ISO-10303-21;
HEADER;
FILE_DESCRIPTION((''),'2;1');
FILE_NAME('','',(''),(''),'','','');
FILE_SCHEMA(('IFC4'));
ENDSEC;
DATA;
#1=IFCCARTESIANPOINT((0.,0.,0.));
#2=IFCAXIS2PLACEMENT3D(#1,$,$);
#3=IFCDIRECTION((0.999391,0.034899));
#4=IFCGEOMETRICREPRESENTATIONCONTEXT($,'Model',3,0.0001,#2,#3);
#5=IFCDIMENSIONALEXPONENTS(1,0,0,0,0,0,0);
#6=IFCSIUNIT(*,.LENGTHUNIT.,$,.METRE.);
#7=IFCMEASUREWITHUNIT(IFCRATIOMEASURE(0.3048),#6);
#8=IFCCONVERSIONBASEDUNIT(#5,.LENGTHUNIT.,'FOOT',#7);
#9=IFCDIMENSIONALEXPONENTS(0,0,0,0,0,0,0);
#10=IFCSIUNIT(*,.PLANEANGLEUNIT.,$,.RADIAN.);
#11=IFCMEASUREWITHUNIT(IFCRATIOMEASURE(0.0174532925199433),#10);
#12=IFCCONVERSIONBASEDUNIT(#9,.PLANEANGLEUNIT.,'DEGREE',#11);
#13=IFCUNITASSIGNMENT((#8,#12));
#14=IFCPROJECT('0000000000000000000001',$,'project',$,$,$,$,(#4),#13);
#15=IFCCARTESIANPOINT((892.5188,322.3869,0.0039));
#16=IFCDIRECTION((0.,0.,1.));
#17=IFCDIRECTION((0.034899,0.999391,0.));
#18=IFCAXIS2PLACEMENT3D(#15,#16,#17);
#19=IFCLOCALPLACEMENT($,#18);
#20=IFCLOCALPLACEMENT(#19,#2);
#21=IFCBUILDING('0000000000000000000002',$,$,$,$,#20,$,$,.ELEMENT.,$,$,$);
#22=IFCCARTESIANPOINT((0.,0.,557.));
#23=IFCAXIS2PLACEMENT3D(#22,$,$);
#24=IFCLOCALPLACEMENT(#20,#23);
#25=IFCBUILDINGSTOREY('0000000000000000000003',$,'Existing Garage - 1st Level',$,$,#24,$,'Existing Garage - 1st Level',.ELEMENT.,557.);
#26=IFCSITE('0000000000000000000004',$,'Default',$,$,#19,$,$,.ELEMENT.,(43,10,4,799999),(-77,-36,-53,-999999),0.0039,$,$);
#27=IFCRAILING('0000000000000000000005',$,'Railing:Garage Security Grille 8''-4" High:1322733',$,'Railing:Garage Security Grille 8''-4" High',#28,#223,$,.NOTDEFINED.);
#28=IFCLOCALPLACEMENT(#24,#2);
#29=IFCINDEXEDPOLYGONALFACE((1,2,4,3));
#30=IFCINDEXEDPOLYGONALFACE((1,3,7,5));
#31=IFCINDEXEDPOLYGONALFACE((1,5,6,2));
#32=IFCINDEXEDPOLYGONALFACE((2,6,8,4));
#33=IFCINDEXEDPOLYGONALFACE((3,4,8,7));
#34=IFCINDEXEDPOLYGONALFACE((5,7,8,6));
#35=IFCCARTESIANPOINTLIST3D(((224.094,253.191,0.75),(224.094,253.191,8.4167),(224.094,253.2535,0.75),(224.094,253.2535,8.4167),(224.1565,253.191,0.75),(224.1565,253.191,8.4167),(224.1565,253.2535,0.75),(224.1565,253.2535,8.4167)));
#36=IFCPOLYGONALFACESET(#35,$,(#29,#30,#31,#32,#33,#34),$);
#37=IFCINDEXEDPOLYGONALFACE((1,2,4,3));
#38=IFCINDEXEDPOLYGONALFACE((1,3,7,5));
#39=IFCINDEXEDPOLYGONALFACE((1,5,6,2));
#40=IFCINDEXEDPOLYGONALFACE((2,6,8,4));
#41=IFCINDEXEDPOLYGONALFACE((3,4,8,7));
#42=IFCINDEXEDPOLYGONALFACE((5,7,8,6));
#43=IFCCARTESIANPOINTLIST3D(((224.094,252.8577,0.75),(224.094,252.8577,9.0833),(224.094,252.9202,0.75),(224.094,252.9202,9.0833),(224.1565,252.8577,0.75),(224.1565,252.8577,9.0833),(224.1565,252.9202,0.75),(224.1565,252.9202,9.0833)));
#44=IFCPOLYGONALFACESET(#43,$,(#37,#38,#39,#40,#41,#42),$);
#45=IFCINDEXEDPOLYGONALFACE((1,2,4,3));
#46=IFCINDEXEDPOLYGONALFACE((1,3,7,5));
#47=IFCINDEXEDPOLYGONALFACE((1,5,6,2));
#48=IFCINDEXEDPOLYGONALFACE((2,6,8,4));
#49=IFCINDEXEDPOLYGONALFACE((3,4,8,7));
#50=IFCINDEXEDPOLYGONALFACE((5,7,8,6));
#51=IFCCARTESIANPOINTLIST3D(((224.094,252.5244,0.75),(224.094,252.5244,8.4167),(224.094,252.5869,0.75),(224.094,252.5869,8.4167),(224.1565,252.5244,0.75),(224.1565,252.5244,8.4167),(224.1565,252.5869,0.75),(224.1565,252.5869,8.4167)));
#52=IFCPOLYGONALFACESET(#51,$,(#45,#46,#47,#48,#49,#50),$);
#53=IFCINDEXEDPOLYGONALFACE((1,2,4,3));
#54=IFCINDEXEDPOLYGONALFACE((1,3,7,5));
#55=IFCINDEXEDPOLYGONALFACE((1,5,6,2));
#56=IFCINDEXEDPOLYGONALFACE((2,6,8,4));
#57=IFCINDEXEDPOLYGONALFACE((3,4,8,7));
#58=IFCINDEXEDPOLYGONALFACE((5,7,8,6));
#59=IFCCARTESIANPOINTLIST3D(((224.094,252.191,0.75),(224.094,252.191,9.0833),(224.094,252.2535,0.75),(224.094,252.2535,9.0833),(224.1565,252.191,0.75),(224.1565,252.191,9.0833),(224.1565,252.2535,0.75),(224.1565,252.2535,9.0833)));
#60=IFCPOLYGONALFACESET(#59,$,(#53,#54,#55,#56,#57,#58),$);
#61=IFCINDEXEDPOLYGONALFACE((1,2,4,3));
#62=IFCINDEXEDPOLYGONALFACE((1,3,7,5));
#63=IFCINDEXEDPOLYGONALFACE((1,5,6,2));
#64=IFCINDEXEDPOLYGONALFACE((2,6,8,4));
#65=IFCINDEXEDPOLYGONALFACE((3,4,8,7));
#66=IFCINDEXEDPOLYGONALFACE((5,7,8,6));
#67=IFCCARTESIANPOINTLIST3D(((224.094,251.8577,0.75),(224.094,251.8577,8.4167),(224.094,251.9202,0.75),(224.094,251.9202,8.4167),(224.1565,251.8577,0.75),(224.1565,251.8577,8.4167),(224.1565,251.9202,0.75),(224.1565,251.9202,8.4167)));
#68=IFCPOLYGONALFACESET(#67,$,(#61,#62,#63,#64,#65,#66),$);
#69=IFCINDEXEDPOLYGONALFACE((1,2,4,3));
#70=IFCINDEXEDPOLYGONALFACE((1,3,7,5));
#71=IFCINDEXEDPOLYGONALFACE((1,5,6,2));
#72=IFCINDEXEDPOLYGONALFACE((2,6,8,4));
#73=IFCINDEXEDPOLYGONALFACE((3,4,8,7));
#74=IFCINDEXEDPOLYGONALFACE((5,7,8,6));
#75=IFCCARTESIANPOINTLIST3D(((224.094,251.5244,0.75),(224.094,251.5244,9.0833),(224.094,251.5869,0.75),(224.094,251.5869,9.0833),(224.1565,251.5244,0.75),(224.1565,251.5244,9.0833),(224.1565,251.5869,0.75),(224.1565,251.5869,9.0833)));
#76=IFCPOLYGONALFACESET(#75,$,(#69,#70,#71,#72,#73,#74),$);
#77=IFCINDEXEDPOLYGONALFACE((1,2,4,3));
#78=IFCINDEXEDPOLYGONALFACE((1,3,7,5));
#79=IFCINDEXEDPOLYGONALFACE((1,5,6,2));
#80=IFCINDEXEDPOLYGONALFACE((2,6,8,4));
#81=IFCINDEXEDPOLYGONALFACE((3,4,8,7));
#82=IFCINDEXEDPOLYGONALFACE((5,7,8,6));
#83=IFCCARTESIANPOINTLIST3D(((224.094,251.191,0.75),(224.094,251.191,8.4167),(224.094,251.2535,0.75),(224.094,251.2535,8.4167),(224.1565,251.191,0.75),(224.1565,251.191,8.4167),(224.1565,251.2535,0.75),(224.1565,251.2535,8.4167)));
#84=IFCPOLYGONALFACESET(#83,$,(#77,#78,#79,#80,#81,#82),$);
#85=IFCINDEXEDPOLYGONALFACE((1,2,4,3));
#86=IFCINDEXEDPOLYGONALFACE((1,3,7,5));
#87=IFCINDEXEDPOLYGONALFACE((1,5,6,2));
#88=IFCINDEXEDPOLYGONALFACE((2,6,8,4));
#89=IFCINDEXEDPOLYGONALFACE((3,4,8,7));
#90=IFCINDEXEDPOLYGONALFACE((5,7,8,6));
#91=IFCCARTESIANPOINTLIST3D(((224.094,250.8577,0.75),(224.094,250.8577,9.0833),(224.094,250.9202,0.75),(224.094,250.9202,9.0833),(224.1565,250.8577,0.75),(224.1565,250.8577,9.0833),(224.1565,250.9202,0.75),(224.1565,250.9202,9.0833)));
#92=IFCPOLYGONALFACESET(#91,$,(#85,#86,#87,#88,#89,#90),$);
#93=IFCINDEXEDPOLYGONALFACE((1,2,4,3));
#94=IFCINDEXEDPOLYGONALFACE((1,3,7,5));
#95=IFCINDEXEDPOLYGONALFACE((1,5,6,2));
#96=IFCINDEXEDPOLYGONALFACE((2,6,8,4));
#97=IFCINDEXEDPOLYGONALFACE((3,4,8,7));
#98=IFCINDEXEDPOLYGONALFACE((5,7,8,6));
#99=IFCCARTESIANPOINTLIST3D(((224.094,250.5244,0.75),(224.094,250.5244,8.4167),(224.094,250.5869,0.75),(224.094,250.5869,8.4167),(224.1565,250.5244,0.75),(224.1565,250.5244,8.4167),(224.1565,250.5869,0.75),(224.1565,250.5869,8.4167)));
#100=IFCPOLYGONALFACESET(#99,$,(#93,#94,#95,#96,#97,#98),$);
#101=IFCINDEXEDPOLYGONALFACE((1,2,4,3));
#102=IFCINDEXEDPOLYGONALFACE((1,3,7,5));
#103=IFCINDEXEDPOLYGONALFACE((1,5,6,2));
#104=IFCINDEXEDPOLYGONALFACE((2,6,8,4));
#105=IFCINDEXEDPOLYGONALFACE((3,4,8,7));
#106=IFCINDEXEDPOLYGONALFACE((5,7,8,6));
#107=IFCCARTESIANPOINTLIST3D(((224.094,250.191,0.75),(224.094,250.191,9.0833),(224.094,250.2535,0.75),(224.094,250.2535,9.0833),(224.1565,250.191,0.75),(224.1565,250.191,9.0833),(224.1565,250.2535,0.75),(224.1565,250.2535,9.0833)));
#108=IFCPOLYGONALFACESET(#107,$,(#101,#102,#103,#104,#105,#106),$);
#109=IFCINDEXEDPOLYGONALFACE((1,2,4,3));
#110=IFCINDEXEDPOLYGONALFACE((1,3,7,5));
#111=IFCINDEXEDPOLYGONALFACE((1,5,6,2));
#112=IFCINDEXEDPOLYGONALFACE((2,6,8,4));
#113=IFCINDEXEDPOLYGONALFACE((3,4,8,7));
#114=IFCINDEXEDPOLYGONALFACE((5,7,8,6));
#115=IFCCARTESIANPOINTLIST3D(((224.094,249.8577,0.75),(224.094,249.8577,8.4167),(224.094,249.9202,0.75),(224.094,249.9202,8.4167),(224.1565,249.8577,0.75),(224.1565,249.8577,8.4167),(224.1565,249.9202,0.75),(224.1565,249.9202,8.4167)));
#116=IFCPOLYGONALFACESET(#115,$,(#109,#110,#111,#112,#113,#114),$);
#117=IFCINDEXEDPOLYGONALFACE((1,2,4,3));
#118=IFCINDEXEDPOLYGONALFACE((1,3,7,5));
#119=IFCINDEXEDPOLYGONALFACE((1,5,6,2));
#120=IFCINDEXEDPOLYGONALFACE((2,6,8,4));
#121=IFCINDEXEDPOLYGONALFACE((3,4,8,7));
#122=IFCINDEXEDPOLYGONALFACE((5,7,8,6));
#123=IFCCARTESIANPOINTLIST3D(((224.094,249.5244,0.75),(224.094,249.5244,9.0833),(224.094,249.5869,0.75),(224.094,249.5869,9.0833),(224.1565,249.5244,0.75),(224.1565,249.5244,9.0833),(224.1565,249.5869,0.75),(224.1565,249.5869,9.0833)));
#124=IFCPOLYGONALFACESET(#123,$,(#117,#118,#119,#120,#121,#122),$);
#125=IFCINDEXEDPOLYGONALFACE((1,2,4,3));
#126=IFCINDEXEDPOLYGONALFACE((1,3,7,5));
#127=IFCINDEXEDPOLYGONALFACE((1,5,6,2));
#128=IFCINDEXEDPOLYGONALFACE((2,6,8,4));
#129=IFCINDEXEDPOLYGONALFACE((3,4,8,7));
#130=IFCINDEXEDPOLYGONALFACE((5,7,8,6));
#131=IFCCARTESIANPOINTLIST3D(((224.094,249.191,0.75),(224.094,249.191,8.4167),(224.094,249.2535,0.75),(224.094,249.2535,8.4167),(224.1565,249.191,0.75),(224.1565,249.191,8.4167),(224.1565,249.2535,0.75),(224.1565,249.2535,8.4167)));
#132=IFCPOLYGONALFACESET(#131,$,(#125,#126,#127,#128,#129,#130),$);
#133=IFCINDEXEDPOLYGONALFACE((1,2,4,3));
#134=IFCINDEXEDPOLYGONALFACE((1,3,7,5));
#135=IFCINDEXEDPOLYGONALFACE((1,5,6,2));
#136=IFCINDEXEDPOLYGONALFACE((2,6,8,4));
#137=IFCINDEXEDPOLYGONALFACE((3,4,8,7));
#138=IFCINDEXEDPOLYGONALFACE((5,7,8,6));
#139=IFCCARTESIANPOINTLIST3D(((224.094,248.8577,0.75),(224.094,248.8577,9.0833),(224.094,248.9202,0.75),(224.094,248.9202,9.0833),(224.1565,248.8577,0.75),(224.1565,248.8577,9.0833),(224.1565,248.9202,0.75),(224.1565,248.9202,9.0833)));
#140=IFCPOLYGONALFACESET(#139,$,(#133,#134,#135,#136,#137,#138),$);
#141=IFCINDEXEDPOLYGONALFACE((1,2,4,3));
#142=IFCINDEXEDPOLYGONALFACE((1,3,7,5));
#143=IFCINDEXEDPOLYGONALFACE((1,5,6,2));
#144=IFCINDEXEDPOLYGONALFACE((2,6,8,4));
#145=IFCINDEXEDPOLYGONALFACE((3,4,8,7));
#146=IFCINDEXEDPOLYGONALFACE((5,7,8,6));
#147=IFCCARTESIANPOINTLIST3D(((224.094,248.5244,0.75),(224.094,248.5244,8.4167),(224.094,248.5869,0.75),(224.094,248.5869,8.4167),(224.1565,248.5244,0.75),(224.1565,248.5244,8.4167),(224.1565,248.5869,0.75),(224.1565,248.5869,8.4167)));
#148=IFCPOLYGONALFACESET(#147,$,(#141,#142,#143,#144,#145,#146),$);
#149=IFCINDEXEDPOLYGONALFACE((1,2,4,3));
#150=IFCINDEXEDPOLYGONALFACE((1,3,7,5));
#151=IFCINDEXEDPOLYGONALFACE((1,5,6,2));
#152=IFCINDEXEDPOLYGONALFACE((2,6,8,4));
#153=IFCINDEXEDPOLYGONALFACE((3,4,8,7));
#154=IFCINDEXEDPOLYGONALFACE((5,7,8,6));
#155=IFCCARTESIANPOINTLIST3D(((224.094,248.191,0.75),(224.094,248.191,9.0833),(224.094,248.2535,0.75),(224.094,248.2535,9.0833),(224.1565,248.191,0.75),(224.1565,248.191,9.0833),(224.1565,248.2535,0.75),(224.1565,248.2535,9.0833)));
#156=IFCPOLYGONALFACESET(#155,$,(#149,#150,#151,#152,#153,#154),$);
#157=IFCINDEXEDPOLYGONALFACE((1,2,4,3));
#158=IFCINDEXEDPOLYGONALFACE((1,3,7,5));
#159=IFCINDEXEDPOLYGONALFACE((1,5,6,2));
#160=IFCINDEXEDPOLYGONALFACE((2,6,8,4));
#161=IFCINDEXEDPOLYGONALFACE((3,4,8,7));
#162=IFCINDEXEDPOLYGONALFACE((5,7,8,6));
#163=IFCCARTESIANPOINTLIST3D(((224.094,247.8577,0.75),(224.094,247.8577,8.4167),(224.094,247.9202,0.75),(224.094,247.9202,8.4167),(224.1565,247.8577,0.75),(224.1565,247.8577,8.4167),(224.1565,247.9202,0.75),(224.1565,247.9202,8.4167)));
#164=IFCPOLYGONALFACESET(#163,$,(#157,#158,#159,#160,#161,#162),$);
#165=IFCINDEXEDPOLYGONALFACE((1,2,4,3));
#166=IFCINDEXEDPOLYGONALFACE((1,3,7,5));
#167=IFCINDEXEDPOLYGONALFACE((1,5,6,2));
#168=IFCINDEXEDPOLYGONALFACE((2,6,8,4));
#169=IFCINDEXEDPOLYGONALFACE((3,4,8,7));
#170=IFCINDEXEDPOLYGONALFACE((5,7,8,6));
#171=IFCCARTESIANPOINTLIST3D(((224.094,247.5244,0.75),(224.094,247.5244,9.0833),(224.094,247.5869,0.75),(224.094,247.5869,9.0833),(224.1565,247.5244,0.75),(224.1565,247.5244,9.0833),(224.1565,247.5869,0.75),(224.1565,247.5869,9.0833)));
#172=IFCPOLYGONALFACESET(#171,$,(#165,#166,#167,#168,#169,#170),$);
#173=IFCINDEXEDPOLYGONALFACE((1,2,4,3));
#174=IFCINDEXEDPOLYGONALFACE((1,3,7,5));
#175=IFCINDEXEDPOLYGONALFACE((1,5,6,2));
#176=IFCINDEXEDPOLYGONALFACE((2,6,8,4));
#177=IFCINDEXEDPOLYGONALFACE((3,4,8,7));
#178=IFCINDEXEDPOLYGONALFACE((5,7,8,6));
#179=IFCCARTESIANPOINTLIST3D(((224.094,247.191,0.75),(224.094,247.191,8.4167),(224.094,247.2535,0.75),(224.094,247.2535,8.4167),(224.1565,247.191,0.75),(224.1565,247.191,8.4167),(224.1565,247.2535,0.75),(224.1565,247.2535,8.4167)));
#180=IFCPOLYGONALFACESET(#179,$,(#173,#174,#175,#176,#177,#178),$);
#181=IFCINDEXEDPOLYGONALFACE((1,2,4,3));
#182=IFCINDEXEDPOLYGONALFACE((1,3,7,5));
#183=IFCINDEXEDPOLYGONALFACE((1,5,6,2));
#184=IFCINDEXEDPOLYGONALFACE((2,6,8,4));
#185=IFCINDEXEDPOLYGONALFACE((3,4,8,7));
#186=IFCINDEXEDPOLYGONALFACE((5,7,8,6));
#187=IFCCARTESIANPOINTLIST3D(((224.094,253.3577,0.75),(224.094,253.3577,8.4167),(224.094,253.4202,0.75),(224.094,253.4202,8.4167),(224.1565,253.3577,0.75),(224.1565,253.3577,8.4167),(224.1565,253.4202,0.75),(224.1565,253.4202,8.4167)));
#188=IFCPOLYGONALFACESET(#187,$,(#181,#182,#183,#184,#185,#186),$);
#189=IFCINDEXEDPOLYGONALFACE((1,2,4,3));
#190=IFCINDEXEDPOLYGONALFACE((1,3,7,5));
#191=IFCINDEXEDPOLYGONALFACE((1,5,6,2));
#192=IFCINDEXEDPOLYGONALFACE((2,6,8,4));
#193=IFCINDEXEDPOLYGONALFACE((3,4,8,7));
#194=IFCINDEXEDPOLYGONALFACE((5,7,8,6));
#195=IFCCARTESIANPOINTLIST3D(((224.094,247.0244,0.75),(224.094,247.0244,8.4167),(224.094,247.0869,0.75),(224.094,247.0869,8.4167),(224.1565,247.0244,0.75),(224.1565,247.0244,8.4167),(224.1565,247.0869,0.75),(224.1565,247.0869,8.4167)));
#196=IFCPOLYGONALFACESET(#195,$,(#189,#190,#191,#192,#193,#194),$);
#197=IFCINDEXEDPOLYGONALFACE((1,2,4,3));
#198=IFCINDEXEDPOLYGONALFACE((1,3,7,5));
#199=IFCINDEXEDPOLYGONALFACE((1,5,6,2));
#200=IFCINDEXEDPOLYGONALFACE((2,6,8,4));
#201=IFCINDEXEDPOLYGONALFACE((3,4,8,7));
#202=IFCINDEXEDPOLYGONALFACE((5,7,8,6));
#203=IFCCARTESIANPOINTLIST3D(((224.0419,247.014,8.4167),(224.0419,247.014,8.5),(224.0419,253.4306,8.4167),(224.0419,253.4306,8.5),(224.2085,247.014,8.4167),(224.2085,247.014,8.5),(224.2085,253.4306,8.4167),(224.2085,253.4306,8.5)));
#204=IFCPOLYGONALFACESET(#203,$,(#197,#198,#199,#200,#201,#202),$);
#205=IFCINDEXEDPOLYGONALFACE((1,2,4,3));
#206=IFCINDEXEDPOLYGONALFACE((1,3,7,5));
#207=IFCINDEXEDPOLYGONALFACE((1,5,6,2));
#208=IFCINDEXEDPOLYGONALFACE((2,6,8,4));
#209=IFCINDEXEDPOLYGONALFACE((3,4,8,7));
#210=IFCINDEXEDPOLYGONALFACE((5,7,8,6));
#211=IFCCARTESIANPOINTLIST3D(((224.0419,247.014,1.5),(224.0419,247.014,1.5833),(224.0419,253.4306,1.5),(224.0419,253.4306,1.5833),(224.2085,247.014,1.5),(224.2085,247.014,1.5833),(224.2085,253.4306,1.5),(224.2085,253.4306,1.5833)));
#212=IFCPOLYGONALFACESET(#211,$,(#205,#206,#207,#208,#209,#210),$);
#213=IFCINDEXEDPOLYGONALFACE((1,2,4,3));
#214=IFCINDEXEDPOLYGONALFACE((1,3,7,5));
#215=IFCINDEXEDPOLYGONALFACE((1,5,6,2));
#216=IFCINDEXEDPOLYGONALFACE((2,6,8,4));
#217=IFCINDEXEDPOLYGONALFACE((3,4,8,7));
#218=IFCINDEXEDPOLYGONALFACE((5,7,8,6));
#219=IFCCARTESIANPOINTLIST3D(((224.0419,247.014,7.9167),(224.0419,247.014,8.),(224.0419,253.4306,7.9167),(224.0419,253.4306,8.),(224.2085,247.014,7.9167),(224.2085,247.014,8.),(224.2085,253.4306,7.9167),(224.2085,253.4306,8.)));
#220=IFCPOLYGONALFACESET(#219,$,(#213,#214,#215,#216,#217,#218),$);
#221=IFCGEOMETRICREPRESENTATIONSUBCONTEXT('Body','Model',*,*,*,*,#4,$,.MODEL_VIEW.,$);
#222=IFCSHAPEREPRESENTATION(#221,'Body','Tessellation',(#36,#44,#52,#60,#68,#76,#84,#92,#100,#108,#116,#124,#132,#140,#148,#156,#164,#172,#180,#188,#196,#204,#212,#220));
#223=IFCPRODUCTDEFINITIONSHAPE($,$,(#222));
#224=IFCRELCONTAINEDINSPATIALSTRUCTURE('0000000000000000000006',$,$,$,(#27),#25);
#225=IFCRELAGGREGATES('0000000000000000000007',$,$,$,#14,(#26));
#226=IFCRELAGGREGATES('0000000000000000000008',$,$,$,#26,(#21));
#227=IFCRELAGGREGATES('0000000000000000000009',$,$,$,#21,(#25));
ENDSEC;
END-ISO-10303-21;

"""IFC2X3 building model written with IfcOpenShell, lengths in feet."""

from ifc_helpers import new_model, entity, si_unit, converted_unit, direction, frame, frame_2d, origin, origin_2d_with_axis, place, context, subcontext, project, spatial, rectangle, extrude, element, save


model = new_model("IFC2X3")

# Units and contexts
model_context = context("Model", 3, precision=0.0001, world=origin(), true_north=direction((0.999391, 0.034899)))
body_context = subcontext(model_context, "Body", "Model", "MODEL_VIEW")
ifc_project = project(units=[converted_unit("LENGTHUNIT", "FOOT", entity("IfcRatioMeasure", 0.3048), si_unit("LENGTHUNIT", "METRE"), dimensions=[1, 0, 0, 0, 0, 0, 0]), converted_unit("PLANEANGLEUNIT", "DEGREE", entity("IfcRatioMeasure", 0.0174532925199433), si_unit("PLANEANGLEUNIT", "RADIAN"), dimensions=[0, 0, 0, 0, 0, 0, 0])], contexts=[model_context])

# Site, building, storey
site_placement = place(None, frame((892.5188, 322.3869, 0.0039), z_axis=(0.0, 0.0, 1.0), x_axis=(0.034899, 0.999391, 0.0)))
site = spatial("IfcSite", under=ifc_project, at=site_placement, Name="Default", CompositionType="ELEMENT", RefLatitude=(43, 10, 4, 799999), RefLongitude=(-77, -36, -53, -999999), RefElevation=0.0039)
building_placement = place(site_placement, origin())
building = spatial("IfcBuilding", under=site, at=building_placement, CompositionType="ELEMENT")
storey_placement = place(building_placement, frame((0.0, 0.0, 557.0)))
storey = spatial("IfcBuildingStorey", under=building, at=storey_placement, Name="Existing Garage - 1st Level", LongName="Existing Garage - 1st Level", CompositionType="ELEMENT", Elevation=557.0)

# Railing
railing_1_placement = place(storey_placement, origin())
element("IfcRailing", 1, at=railing_1_placement, inside=storey, Name="Railing:Garage Security Grille 8'-4\" High:1322733", ObjectType="Railing:Garage Security Grille 8'-4\" High", PredefinedType="NOTDEFINED", context=body_context, shape_type="SweptSolid", body=[
    extrude(rectangle(XDim=0.0625, YDim=0.0625, at=origin_2d_with_axis()), frame((224.1252, 253.2223, 0.75), z_axis=(0.0, 0.0, 1.0), x_axis=(0.0, 1.0, 0.0)), (0.0, 0.0, 1.0), 7.6667),
    extrude(rectangle(XDim=0.0625, YDim=0.0625, at=origin_2d_with_axis()), frame((224.1252, 252.889, 0.75), z_axis=(0.0, 0.0, 1.0), x_axis=(0.0, 1.0, 0.0)), (0.0, 0.0, 1.0), 8.3333),
    extrude(rectangle(XDim=0.0625, YDim=0.0625, at=origin_2d_with_axis()), frame((224.1252, 252.5556, 0.75), z_axis=(0.0, 0.0, 1.0), x_axis=(0.0, 1.0, 0.0)), (0.0, 0.0, 1.0), 7.6667),
    extrude(rectangle(XDim=0.0625, YDim=0.0625, at=origin_2d_with_axis()), frame((224.1252, 252.2223, 0.75), z_axis=(0.0, 0.0, 1.0), x_axis=(0.0, 1.0, 0.0)), (0.0, 0.0, 1.0), 8.3333),
    extrude(rectangle(XDim=0.0625, YDim=0.0625, at=origin_2d_with_axis()), frame((224.1252, 251.889, 0.75), z_axis=(0.0, 0.0, 1.0), x_axis=(0.0, 1.0, 0.0)), (0.0, 0.0, 1.0), 7.6667),
    extrude(rectangle(XDim=0.0625, YDim=0.0625, at=origin_2d_with_axis()), frame((224.1252, 251.5556, 0.75), z_axis=(0.0, 0.0, 1.0), x_axis=(0.0, 1.0, 0.0)), (0.0, 0.0, 1.0), 8.3333),
    extrude(rectangle(XDim=0.0625, YDim=0.0625, at=origin_2d_with_axis()), frame((224.1252, 251.2223, 0.75), z_axis=(0.0, 0.0, 1.0), x_axis=(0.0, 1.0, 0.0)), (0.0, 0.0, 1.0), 7.6667),
    extrude(rectangle(XDim=0.0625, YDim=0.0625, at=origin_2d_with_axis()), frame((224.1252, 250.889, 0.75), z_axis=(0.0, 0.0, 1.0), x_axis=(0.0, 1.0, 0.0)), (0.0, 0.0, 1.0), 8.3333),
    extrude(rectangle(XDim=0.0625, YDim=0.0625, at=origin_2d_with_axis()), frame((224.1252, 250.5556, 0.75), z_axis=(0.0, 0.0, 1.0), x_axis=(0.0, 1.0, 0.0)), (0.0, 0.0, 1.0), 7.6667),
    extrude(rectangle(XDim=0.0625, YDim=0.0625, at=origin_2d_with_axis()), frame((224.1252, 250.2223, 0.75), z_axis=(0.0, 0.0, 1.0), x_axis=(0.0, 1.0, 0.0)), (0.0, 0.0, 1.0), 8.3333),
    extrude(rectangle(XDim=0.0625, YDim=0.0625, at=origin_2d_with_axis()), frame((224.1252, 249.889, 0.75), z_axis=(0.0, 0.0, 1.0), x_axis=(0.0, 1.0, 0.0)), (0.0, 0.0, 1.0), 7.6667),
    extrude(rectangle(XDim=0.0625, YDim=0.0625, at=origin_2d_with_axis()), frame((224.1252, 249.5556, 0.75), z_axis=(0.0, 0.0, 1.0), x_axis=(0.0, 1.0, 0.0)), (0.0, 0.0, 1.0), 8.3333),
    extrude(rectangle(XDim=0.0625, YDim=0.0625, at=origin_2d_with_axis()), frame((224.1252, 249.2223, 0.75), z_axis=(0.0, 0.0, 1.0), x_axis=(0.0, 1.0, 0.0)), (0.0, 0.0, 1.0), 7.6667),
    extrude(rectangle(XDim=0.0625, YDim=0.0625, at=origin_2d_with_axis()), frame((224.1252, 248.889, 0.75), z_axis=(0.0, 0.0, 1.0), x_axis=(0.0, 1.0, 0.0)), (0.0, 0.0, 1.0), 8.3333),
    extrude(rectangle(XDim=0.0625, YDim=0.0625, at=origin_2d_with_axis()), frame((224.1252, 248.5556, 0.75), z_axis=(0.0, 0.0, 1.0), x_axis=(0.0, 1.0, 0.0)), (0.0, 0.0, 1.0), 7.6667),
    extrude(rectangle(XDim=0.0625, YDim=0.0625, at=origin_2d_with_axis()), frame((224.1252, 248.2223, 0.75), z_axis=(0.0, 0.0, 1.0), x_axis=(0.0, 1.0, 0.0)), (0.0, 0.0, 1.0), 8.3333),
    extrude(rectangle(XDim=0.0625, YDim=0.0625, at=origin_2d_with_axis()), frame((224.1252, 247.889, 0.75), z_axis=(0.0, 0.0, 1.0), x_axis=(0.0, 1.0, 0.0)), (0.0, 0.0, 1.0), 7.6667),
    extrude(rectangle(XDim=0.0625, YDim=0.0625, at=origin_2d_with_axis()), frame((224.1252, 247.5556, 0.75), z_axis=(0.0, 0.0, 1.0), x_axis=(0.0, 1.0, 0.0)), (0.0, 0.0, 1.0), 8.3333),
    extrude(rectangle(XDim=0.0625, YDim=0.0625, at=origin_2d_with_axis()), frame((224.1252, 247.2223, 0.75), z_axis=(0.0, 0.0, 1.0), x_axis=(0.0, 1.0, 0.0)), (0.0, 0.0, 1.0), 7.6667),
    extrude(rectangle(XDim=0.0625, YDim=0.0625, at=origin_2d_with_axis()), frame((224.1252, 253.389, 0.75), z_axis=(0.0, 0.0, 1.0), x_axis=(0.0, 1.0, 0.0)), (0.0, 0.0, 1.0), 7.6667),
    extrude(rectangle(XDim=0.0625, YDim=0.0625, at=origin_2d_with_axis()), frame((224.1252, 247.0556, 0.75), z_axis=(0.0, 0.0, 1.0), x_axis=(0.0, 1.0, 0.0)), (0.0, 0.0, 1.0), 7.6667),
    extrude(rectangle(XDim=6.4167, YDim=0.1667, at=frame_2d((0.0, 0.0), x_axis=(1.0, 0.0))), frame((224.1252, 250.2223, 8.4167), z_axis=(0.0, 0.0, 1.0), x_axis=(0.0, 1.0, 0.0)), (0.0, 0.0, 1.0), 0.0833),
    extrude(rectangle(XDim=6.4167, YDim=0.1667, at=frame_2d((0.0, 0.0), x_axis=(1.0, 0.0))), frame((224.1252, 250.2223, 1.5), z_axis=(0.0, 0.0, 1.0), x_axis=(0.0, 1.0, 0.0)), (0.0, 0.0, 1.0), 0.0833),
    extrude(rectangle(XDim=6.4167, YDim=0.1667, at=frame_2d((0.0, 0.0), x_axis=(1.0, 0.0))), frame((224.1252, 250.2223, 7.9167), z_axis=(0.0, 0.0, 1.0), x_axis=(0.0, 1.0, 0.0)), (0.0, 0.0, 1.0), 0.0833),
])

save(model, "model.ifc")
